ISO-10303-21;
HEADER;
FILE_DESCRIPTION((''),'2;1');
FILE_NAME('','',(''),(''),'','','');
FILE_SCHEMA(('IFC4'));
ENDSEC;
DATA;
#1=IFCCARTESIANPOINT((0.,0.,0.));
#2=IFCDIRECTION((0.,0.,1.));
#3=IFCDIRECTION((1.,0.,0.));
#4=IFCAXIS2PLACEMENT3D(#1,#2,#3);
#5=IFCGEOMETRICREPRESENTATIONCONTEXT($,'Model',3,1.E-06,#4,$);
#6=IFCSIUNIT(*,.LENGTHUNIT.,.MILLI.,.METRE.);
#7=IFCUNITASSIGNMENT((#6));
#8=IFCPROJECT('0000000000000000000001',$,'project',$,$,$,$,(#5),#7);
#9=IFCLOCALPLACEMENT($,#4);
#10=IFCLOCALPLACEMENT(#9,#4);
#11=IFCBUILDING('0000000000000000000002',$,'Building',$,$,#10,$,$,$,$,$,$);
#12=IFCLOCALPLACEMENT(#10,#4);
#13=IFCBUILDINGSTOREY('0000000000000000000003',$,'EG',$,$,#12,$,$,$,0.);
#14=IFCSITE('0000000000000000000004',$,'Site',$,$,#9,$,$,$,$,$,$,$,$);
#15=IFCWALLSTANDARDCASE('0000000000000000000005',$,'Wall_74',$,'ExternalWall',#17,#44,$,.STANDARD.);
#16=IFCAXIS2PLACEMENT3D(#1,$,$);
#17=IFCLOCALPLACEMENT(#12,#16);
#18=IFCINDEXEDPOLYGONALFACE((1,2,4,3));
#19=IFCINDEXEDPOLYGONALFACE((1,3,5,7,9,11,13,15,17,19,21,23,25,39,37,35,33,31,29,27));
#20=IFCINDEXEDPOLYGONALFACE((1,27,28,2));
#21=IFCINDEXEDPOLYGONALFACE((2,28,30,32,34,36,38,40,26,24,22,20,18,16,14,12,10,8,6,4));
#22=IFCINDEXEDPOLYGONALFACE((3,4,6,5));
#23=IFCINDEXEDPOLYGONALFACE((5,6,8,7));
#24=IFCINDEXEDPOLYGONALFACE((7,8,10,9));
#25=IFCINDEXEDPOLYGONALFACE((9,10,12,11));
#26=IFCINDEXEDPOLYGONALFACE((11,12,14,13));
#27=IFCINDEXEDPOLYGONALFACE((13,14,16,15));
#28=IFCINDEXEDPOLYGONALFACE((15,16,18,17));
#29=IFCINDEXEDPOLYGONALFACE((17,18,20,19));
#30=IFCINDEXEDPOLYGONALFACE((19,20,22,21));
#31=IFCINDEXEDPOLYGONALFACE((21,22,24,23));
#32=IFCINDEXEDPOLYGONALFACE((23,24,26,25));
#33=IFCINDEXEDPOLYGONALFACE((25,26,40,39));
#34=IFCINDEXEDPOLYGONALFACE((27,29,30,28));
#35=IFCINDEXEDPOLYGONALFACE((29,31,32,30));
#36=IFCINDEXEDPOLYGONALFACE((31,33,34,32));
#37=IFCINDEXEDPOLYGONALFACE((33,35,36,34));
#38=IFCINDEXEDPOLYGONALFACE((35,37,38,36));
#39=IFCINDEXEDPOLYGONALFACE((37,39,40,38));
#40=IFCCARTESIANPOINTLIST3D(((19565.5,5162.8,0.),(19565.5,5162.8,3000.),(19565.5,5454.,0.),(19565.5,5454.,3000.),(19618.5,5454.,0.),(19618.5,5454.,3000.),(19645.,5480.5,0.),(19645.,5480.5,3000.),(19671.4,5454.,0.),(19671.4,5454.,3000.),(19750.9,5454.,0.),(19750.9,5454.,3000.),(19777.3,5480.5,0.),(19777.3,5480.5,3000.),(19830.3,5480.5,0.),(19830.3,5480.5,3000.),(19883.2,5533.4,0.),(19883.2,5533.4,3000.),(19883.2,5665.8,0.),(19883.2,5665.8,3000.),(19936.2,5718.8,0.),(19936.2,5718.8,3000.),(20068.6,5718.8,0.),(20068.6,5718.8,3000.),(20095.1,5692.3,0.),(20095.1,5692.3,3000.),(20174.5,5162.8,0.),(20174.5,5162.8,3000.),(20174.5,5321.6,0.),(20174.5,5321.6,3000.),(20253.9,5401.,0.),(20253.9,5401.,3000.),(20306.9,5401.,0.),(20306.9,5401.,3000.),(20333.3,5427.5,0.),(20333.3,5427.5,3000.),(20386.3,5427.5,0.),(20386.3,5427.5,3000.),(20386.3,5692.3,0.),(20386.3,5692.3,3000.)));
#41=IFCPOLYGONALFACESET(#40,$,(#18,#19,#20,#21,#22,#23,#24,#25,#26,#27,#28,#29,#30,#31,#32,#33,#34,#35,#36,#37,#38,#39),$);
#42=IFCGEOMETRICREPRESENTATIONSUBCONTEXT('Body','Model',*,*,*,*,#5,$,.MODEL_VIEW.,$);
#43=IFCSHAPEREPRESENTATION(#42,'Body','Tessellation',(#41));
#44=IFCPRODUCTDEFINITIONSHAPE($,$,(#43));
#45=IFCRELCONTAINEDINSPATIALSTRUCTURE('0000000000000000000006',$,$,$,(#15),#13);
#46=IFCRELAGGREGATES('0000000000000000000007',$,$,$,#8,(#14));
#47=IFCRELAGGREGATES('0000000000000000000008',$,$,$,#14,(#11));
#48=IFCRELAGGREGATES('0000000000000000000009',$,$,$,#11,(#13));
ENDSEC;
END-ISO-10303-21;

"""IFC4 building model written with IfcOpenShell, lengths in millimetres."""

from ifc_helpers import new_model, si_unit, frame, origin_with_axes, place, context, subcontext, project, spatial, polyline, outline, extrude, element, save


model = new_model("IFC4")

# Units and contexts
model_context = context("Model", 3, precision=1e-06, world=origin_with_axes())
body_context = subcontext(model_context, "Body", "Model", "MODEL_VIEW")
ifc_project = project(units=[si_unit("LENGTHUNIT", "METRE", prefix="MILLI")], contexts=[model_context])

# Site, building, storey
site_placement = place(None, origin_with_axes())
site = spatial("IfcSite", under=ifc_project, at=site_placement, Name="Site")
building_placement = place(site_placement, origin_with_axes())
building = spatial("IfcBuilding", under=site, at=building_placement, Name="Building")
storey_placement = place(building_placement, origin_with_axes())
storey = spatial("IfcBuildingStorey", under=building, at=storey_placement, Name="EG", Elevation=0.0)

# Wall
for number, where, z_axis, x_axis, name in (
    (1, (0.0, 0.0, 0.0), (0.0, 0.0, 1.0), (1.0, 0.0, 0.0), "Wall_74"),
):
    element("IfcWallStandardCase", number, at=place(storey_placement, frame(where, z_axis=z_axis, x_axis=x_axis)), inside=storey, Name=name, ObjectType="ExternalWall", PredefinedType="STANDARD", context=body_context, shape_type="SweptSolid", body=[
        extrude(outline(polyline([(19565.5, 5162.8, 0.0), (19565.5, 5454.0, 0.0), (19618.5, 5454.0, 0.0), (19645.0, 5480.5, 0.0), (19671.4, 5454.0, 0.0), (19750.9, 5454.0, 0.0), (19777.3, 5480.5, 0.0), (19830.3, 5480.5, 0.0), (19883.2, 5533.4, 0.0), (19883.2, 5665.8, 0.0), (19936.2, 5718.8, 0.0), (20068.6, 5718.8, 0.0), (20095.1, 5692.3, 0.0), (20386.3, 5692.3, 0.0), (20386.3, 5427.5, 0.0), (20333.3, 5427.5, 0.0), (20306.9, 5401.0, 0.0), (20253.9, 5401.0, 0.0), (20174.5, 5321.6, 0.0), (20174.5, 5162.8, 0.0), (19565.5, 5162.8, 0.0)])), origin_with_axes(), (0.0, 0.0, 1.0), 3000.0),
    ])

save(model, "model.ifc")
